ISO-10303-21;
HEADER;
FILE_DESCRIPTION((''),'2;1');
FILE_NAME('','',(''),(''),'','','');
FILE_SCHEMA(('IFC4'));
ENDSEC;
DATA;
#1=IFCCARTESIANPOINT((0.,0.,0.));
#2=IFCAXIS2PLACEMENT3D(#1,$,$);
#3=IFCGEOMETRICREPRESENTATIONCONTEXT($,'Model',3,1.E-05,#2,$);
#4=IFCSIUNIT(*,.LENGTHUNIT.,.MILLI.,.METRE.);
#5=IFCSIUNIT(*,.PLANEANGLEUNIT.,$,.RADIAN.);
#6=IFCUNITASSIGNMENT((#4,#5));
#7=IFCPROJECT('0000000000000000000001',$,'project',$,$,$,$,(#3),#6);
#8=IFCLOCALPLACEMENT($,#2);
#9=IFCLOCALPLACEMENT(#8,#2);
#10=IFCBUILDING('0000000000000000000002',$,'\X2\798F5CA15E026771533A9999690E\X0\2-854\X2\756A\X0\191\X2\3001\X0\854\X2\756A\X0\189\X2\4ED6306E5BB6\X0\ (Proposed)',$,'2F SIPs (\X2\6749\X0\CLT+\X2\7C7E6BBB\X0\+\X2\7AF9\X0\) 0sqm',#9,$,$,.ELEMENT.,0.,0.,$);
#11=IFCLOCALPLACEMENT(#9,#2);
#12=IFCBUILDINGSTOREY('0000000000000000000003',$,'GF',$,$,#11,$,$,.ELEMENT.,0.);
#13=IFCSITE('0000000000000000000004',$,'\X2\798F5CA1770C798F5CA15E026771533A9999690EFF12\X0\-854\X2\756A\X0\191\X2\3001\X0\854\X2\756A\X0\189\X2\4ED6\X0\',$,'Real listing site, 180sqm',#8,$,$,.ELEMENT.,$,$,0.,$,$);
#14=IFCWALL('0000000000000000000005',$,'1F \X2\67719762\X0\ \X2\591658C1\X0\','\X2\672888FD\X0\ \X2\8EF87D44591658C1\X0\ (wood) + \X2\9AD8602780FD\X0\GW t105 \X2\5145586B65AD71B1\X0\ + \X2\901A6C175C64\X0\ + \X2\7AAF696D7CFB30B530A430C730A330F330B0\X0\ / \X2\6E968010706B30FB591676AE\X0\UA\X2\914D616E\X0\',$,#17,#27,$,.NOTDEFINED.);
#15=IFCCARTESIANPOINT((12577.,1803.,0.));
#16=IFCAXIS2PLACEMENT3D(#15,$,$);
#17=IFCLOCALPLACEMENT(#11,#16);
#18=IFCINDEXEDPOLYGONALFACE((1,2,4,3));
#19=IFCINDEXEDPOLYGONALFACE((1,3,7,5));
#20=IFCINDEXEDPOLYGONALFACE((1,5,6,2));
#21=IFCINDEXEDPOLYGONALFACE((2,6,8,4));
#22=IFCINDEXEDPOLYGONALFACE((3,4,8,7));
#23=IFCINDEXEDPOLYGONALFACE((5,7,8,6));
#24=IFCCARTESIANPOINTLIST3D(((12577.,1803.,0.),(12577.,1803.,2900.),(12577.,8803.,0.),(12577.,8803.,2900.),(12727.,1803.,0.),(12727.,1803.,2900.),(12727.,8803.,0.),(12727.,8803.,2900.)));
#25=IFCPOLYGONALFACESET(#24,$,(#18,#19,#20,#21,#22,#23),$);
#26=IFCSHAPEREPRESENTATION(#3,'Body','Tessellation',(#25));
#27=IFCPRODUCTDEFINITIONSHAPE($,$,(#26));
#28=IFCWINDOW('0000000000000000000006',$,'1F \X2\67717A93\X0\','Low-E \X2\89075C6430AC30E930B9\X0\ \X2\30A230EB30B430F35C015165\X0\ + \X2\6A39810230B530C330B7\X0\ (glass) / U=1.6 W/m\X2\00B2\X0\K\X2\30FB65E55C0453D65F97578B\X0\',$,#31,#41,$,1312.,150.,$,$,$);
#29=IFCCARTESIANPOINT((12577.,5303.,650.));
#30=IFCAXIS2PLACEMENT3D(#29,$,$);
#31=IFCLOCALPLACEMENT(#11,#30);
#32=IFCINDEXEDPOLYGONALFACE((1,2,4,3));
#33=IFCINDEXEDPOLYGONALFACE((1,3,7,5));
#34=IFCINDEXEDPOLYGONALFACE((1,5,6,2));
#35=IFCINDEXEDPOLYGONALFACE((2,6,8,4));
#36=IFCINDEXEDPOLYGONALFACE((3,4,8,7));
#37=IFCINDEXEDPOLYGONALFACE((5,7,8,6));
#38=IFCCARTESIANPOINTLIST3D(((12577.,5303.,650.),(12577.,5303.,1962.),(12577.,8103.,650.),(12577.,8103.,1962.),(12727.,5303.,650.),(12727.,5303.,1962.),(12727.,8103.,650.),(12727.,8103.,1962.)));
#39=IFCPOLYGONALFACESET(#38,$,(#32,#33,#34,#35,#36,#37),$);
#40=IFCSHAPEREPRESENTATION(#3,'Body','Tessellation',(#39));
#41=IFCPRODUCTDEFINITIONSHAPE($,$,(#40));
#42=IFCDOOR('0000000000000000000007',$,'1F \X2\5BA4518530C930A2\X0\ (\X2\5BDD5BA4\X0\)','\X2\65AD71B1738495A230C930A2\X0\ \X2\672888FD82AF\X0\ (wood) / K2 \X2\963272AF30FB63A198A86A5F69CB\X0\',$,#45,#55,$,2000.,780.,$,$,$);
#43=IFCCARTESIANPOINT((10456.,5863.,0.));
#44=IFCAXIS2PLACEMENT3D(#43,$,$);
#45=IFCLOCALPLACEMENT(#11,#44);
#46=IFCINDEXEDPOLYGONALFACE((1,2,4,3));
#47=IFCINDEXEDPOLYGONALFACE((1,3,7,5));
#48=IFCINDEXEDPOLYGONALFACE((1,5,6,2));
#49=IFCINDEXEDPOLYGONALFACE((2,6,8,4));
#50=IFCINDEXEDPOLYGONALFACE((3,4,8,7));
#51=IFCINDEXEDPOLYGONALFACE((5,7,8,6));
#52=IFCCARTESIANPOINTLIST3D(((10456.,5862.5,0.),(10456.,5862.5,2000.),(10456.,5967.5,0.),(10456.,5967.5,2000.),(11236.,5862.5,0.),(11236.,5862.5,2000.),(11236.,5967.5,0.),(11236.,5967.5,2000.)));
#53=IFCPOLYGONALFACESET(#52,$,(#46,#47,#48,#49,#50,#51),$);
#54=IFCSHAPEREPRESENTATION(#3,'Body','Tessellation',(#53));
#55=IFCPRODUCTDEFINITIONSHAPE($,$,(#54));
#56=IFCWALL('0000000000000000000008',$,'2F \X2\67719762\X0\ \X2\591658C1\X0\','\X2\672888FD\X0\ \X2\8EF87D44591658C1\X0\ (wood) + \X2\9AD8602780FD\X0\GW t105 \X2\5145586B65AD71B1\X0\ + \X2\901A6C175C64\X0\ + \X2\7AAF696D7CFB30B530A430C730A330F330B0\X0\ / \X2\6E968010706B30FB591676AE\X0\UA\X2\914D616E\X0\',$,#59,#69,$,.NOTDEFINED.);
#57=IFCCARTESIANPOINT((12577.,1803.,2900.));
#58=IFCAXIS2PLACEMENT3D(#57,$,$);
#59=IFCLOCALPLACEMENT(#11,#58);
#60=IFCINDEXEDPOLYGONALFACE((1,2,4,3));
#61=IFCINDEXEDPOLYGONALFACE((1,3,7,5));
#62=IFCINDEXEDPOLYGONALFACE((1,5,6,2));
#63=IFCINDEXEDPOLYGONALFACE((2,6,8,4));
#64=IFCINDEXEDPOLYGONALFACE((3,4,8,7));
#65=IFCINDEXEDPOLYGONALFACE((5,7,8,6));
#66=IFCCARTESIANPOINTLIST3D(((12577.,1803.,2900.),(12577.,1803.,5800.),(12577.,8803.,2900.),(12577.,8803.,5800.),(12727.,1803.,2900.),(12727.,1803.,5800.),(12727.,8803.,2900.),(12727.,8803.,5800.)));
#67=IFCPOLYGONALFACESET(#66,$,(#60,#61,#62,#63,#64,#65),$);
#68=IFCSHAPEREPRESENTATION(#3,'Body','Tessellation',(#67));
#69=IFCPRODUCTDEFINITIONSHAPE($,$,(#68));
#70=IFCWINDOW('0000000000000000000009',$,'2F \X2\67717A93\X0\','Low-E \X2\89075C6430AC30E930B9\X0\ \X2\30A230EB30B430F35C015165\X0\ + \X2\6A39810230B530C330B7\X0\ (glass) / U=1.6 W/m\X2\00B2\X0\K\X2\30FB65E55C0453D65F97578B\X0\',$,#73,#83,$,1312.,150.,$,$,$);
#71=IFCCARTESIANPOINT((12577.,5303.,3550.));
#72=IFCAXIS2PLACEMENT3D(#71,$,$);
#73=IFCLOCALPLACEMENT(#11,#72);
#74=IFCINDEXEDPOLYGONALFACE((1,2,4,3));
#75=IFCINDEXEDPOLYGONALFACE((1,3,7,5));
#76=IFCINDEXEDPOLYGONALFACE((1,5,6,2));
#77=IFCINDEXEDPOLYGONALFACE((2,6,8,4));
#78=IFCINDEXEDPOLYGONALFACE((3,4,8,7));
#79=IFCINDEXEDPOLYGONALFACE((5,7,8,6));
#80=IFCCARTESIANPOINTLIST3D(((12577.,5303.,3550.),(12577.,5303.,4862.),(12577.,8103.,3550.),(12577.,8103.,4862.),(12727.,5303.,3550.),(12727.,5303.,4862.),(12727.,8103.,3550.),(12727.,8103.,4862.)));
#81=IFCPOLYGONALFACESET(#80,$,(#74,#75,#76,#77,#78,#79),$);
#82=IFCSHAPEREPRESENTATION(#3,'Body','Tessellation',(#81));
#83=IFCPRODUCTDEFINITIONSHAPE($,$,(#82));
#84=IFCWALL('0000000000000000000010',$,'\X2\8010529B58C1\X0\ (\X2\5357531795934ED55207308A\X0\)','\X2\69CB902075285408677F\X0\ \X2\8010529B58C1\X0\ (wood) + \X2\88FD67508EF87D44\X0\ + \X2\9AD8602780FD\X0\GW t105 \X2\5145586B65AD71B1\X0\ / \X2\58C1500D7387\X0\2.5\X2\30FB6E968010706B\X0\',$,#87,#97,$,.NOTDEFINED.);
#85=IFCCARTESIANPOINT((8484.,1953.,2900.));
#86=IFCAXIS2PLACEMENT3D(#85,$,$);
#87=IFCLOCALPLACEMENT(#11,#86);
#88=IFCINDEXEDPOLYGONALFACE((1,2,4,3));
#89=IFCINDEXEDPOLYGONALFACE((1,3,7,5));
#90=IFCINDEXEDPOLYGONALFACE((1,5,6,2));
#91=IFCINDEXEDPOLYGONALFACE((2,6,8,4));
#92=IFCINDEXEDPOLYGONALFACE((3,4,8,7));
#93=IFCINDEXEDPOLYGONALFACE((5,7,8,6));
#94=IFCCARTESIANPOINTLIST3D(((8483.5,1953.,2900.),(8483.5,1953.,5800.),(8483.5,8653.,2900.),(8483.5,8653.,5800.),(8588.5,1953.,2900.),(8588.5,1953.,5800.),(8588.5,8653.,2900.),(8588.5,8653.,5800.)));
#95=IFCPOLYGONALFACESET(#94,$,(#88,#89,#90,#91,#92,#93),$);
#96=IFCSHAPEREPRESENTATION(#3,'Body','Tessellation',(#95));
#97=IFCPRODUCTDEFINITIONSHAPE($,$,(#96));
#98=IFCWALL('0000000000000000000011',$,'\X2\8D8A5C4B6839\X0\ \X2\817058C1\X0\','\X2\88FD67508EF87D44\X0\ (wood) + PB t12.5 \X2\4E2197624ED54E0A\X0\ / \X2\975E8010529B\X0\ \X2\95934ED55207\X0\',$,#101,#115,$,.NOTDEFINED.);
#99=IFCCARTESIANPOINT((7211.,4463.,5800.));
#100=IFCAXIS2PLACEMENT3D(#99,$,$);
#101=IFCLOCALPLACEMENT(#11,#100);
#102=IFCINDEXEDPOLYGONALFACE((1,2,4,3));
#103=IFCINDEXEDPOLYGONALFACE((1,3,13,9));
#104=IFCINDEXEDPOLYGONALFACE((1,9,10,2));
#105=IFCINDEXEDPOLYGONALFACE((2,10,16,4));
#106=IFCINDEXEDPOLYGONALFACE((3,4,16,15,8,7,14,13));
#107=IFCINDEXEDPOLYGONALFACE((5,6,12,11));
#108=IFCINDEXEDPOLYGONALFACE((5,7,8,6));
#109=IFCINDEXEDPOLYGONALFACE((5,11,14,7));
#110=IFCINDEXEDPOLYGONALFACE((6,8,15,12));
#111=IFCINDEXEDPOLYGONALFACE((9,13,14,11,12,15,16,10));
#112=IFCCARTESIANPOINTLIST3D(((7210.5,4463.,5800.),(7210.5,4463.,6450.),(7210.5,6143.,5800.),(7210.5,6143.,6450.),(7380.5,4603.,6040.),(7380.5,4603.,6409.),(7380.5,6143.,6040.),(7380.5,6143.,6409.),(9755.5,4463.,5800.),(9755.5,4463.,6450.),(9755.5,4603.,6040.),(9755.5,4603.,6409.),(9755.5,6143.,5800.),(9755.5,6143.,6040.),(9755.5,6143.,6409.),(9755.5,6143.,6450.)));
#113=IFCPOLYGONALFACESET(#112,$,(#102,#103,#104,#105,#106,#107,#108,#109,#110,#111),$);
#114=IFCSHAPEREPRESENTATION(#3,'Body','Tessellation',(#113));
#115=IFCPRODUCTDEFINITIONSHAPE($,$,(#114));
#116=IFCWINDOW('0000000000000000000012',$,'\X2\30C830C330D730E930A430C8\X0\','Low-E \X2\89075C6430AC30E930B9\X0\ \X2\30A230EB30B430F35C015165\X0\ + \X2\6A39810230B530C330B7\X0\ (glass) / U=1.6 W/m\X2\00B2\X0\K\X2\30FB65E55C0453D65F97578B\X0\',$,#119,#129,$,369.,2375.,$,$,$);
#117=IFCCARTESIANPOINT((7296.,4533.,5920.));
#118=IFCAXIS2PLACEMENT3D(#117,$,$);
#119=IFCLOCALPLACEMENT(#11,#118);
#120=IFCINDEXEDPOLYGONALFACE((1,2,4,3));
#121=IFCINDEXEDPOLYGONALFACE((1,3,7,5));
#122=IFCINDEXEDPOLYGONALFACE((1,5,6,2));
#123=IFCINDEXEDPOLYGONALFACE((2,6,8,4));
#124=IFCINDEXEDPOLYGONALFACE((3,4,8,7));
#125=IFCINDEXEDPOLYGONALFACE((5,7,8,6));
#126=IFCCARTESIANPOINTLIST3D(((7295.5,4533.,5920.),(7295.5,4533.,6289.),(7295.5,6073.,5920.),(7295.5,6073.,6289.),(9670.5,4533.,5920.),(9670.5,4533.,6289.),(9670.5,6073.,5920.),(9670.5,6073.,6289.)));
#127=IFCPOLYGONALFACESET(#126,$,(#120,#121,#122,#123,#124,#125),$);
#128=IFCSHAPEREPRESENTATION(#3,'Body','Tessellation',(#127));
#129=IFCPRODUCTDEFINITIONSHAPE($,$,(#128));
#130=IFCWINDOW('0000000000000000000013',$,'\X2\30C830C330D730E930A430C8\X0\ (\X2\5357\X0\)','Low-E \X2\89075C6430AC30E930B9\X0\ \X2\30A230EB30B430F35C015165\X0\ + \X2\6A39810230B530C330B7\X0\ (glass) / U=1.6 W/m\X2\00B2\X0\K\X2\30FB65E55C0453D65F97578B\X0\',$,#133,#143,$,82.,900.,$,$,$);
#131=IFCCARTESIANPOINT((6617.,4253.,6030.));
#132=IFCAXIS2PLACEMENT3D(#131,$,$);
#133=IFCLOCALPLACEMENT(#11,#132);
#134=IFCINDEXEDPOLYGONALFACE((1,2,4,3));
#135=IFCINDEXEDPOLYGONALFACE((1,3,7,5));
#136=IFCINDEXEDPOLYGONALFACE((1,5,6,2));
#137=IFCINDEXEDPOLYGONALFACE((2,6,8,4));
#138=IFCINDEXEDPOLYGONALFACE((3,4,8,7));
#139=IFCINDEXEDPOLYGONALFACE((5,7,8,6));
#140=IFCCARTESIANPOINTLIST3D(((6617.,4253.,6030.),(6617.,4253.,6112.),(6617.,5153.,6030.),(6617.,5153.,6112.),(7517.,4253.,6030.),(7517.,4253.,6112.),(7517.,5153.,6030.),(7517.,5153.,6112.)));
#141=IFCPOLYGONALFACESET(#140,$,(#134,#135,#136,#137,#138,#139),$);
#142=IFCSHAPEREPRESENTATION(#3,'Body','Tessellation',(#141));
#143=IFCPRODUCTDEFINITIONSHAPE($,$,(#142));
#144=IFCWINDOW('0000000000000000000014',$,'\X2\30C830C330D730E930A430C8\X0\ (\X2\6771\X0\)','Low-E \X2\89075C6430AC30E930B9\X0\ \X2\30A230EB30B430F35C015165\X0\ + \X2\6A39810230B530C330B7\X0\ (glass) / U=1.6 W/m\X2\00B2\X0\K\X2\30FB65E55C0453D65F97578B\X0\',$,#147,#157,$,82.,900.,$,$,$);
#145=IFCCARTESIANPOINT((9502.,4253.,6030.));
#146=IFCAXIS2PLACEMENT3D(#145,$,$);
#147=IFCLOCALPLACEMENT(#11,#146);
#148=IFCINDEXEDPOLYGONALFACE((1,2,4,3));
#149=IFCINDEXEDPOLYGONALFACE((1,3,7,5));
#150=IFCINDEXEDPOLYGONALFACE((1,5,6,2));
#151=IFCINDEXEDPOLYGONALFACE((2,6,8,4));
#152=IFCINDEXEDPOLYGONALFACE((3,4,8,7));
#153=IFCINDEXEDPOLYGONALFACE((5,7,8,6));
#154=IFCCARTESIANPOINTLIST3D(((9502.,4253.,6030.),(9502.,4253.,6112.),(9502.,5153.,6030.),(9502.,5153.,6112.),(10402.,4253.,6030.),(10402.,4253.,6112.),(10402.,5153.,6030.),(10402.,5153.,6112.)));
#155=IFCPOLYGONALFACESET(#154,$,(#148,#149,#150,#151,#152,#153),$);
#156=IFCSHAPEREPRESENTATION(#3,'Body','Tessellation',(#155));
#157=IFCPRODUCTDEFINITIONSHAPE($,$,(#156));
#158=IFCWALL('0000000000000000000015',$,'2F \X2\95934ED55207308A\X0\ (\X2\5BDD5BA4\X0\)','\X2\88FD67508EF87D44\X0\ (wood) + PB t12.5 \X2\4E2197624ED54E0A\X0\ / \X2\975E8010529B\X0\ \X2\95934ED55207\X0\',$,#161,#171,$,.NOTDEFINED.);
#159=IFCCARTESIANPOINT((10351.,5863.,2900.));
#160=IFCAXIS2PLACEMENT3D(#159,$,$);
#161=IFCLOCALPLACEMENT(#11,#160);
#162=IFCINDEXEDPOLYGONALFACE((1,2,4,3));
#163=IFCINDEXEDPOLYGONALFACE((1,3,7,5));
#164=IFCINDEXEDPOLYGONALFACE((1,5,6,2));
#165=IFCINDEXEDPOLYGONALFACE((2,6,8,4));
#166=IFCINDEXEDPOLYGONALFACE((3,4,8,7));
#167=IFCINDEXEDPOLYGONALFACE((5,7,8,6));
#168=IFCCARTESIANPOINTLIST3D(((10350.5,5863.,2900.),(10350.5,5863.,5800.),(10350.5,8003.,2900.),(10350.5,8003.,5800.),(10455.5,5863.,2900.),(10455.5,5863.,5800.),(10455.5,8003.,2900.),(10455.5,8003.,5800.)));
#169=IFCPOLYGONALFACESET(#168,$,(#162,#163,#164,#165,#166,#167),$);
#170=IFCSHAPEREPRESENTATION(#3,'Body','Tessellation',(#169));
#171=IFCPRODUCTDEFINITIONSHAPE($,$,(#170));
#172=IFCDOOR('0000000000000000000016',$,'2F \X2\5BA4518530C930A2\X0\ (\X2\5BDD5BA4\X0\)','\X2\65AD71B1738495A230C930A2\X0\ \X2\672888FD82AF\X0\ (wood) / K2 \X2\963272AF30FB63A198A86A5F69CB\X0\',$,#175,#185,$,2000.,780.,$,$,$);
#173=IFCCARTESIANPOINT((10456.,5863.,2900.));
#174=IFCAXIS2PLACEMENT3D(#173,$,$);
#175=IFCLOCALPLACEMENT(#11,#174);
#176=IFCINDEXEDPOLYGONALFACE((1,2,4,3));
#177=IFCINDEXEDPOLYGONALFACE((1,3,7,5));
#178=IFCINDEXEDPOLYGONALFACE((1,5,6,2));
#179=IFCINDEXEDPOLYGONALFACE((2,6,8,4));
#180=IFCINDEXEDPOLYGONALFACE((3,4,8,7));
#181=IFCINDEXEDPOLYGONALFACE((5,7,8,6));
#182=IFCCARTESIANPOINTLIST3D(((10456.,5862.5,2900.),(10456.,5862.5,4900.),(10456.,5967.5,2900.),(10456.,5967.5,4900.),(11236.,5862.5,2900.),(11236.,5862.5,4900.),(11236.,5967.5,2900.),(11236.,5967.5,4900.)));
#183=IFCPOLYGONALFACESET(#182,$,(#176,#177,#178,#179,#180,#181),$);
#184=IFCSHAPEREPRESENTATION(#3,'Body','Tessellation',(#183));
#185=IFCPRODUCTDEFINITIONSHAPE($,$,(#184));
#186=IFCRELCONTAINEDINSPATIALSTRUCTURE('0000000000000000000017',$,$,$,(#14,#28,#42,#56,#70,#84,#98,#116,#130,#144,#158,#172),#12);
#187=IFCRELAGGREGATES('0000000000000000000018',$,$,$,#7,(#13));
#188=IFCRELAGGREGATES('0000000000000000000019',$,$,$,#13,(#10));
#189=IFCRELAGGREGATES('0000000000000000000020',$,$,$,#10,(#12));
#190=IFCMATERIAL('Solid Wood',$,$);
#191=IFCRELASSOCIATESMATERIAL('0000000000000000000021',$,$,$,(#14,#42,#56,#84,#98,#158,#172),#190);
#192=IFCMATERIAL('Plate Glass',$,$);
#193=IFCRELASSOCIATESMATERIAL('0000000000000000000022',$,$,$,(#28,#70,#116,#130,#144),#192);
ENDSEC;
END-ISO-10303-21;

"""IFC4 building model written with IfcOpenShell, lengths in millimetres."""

from ifc_helpers import new_model, si_unit, frame, frame_2d, origin, place, context, project, spatial, rectangle, extrude, material, element, fill, save


model = new_model("IFC4")

# Units and contexts
model_context = context("Model", 3, precision=1e-05, world=origin())
ifc_project = project(units=[si_unit("LENGTHUNIT", "METRE", prefix="MILLI"), si_unit("PLANEANGLEUNIT", "RADIAN")], contexts=[model_context])

# Site, building, storey
site_placement = place(None, origin())
site = spatial("IfcSite", under=ifc_project, at=site_placement, Name="福岡県福岡市東区香椎２-854番191、854番189他", ObjectType="Real listing site, 180sqm", CompositionType="ELEMENT", RefElevation=0.0)
building_placement = place(site_placement, origin())
building = spatial("IfcBuilding", under=site, at=building_placement, Name="福岡市東区香椎2-854番191、854番189他の家 (Proposed)", ObjectType="2F SIPs (杉CLT+籾殻+竹) 0sqm", CompositionType="ELEMENT", ElevationOfRefHeight=0.0, ElevationOfTerrain=0.0)
storey_placement = place(building_placement, origin())
storey = spatial("IfcBuildingStorey", under=building, at=storey_placement, Name="GF", CompositionType="ELEMENT", Elevation=0.0)

# Wall, opening, window
ifc_material_1 = material(Name="Solid Wood")
wall_1_placement = place(storey_placement, frame((12577.0, 1803.0, 0.0)))
wall_1 = element("IfcWall", 1, at=wall_1_placement, inside=storey, material=ifc_material_1, Name="1F 東面 外壁", Description="木製 軸組外壁 (wood) + 高性能GW t105 充填断熱 + 通気層 + 窯業系サイディング / 準耐火・外皮UA配慮", PredefinedType="NOTDEFINED", context=model_context, shape_type="SweptSolid", body=[
    extrude(rectangle(XDim=150.0, YDim=7000.0, at=frame_2d((75.0, 3500.0))), frame((12577.0, 1803.0, 0.0)), (0.0, 0.0, 1.0), 2900.0),
])
opening_1_placement = place(storey_placement, frame((12577.0, 5303.0, 650.0)))
opening_1 = element("IfcOpeningElement", 2, at=opening_1_placement, cuts=wall_1, PredefinedType="NOTDEFINED", context=model_context, shape_type="SweptSolid", body=[
    extrude(rectangle(XDim=150.0, YDim=2800.0, at=frame_2d((75.0, 1400.0))), frame((12577.0, 5303.0, 650.0)), (0.0, 0.0, 1.0), 1312.0),
])
ifc_material_2 = material(Name="Plate Glass")
window_1_placement = place(storey_placement, frame((12577.0, 5303.0, 650.0)))
window_1 = element("IfcWindow", 3, at=window_1_placement, inside=storey, material=ifc_material_2, Name="1F 東窓", Description="Low-E 複層ガラス アルゴン封入 + 樹脂サッシ (glass) / U=1.6 W/m²K・日射取得型", OverallHeight=1312.0, OverallWidth=150.0, context=model_context, shape_type="SweptSolid", body=[
    extrude(rectangle(XDim=150.0, YDim=2800.0, at=frame_2d((75.0, 1400.0))), frame((12577.0, 5303.0, 650.0)), (0.0, 0.0, 1.0), 1312.0),
])
fill(opening_1, window_1)

# Door
door_1_placement = place(storey_placement, frame((10456.0, 5863.0, 0.0)))
element("IfcDoor", 4, at=door_1_placement, inside=storey, material=ifc_material_1, Name="1F 室内ドア (寝室)", Description="断熱玄関ドア 木製芯 (wood) / K2 防犯・採風機構", OverallHeight=2000.0, OverallWidth=780.0, context=model_context, shape_type="SweptSolid", body=[
    extrude(rectangle(XDim=780.0, YDim=105.0, at=frame_2d((390.0, 52.0))), frame((10456.0, 5863.0, 0.0)), (0.0, 0.0, 1.0), 2000.0),
])

# Wall, opening, window
wall_2_placement = place(storey_placement, frame((12577.0, 1803.0, 2900.0)))
wall_2 = element("IfcWall", 5, at=wall_2_placement, inside=storey, material=ifc_material_1, Name="2F 東面 外壁", Description="木製 軸組外壁 (wood) + 高性能GW t105 充填断熱 + 通気層 + 窯業系サイディング / 準耐火・外皮UA配慮", PredefinedType="NOTDEFINED", context=model_context, shape_type="SweptSolid", body=[
    extrude(rectangle(XDim=150.0, YDim=7000.0, at=frame_2d((75.0, 3500.0))), frame((12577.0, 1803.0, 2900.0)), (0.0, 0.0, 1.0), 2900.0),
])
opening_2_placement = place(storey_placement, frame((12577.0, 5303.0, 3550.0)))
opening_2 = element("IfcOpeningElement", 6, at=opening_2_placement, cuts=wall_2, PredefinedType="NOTDEFINED", context=model_context, shape_type="SweptSolid", body=[
    extrude(rectangle(XDim=150.0, YDim=2800.0, at=frame_2d((75.0, 1400.0))), frame((12577.0, 5303.0, 3550.0)), (0.0, 0.0, 1.0), 1312.0),
])
window_2_placement = place(storey_placement, frame((12577.0, 5303.0, 3550.0)))
window_2 = element("IfcWindow", 7, at=window_2_placement, inside=storey, material=ifc_material_2, Name="2F 東窓", Description="Low-E 複層ガラス アルゴン封入 + 樹脂サッシ (glass) / U=1.6 W/m²K・日射取得型", OverallHeight=1312.0, OverallWidth=150.0, context=model_context, shape_type="SweptSolid", body=[
    extrude(rectangle(XDim=150.0, YDim=2800.0, at=frame_2d((75.0, 1400.0))), frame((12577.0, 5303.0, 3550.0)), (0.0, 0.0, 1.0), 1312.0),
])
fill(opening_2, window_2)

# Wall
wall_3_placement = place(storey_placement, frame((8484.0, 1953.0, 2900.0)))
element("IfcWall", 8, at=wall_3_placement, inside=storey, material=ifc_material_1, Name="耐力壁 (南北間仕切り)", Description="構造用合板 耐力壁 (wood) + 製材軸組 + 高性能GW t105 充填断熱 / 壁倍率2.5・準耐火", PredefinedType="NOTDEFINED", context=model_context, shape_type="SweptSolid", body=[
    extrude(rectangle(XDim=105.0, YDim=6700.0, at=frame_2d((52.0, 3350.0))), frame((8484.0, 1953.0, 2900.0)), (0.0, 0.0, 1.0), 2900.0),
])

# Wall, openings, windows
wall_4_placement = place(storey_placement, frame((7211.0, 4463.0, 5800.0)))
wall_4 = element("IfcWall", 9, at=wall_4_placement, inside=storey, material=ifc_material_1, Name="越屋根 腰壁", Description="製材軸組 (wood) + PB t12.5 両面仕上 / 非耐力 間仕切", PredefinedType="NOTDEFINED", context=model_context, shape_type="SweptSolid", body=[
    extrude(rectangle(XDim=2545.0, YDim=1680.0, at=frame_2d((1272.0, 840.0))), frame((7211.0, 4463.0, 5800.0)), (0.0, 0.0, 1.0), 650.0),
])
opening_3_placement = place(storey_placement, frame((7296.0, 4533.0, 5920.0)))
opening_3 = element("IfcOpeningElement", 10, at=opening_3_placement, cuts=wall_4, PredefinedType="NOTDEFINED", context=model_context, shape_type="SweptSolid", body=[
    extrude(rectangle(XDim=2375.0, YDim=1540.0, at=frame_2d((1187.0, 770.0))), frame((7296.0, 4533.0, 5920.0)), (0.0, 0.0, 1.0), 369.0),
])
opening_4_placement = place(storey_placement, frame((6617.0, 4253.0, 6030.0)))
opening_4 = element("IfcOpeningElement", 11, at=opening_4_placement, cuts=wall_4, PredefinedType="NOTDEFINED", context=model_context, shape_type="SweptSolid", body=[
    extrude(rectangle(XDim=900.0, YDim=900.0, at=frame_2d((450.0, 450.0))), frame((6617.0, 4253.0, 6030.0)), (0.0, 0.0, 1.0), 82.0),
])
opening_5_placement = place(storey_placement, frame((9502.0, 4253.0, 6030.0)))
opening_5 = element("IfcOpeningElement", 12, at=opening_5_placement, cuts=wall_4, PredefinedType="NOTDEFINED", context=model_context, shape_type="SweptSolid", body=[
    extrude(rectangle(XDim=900.0, YDim=900.0, at=frame_2d((450.0, 450.0))), frame((9502.0, 4253.0, 6030.0)), (0.0, 0.0, 1.0), 82.0),
])
window_3_placement = place(storey_placement, frame((7296.0, 4533.0, 5920.0)))
window_3 = element("IfcWindow", 13, at=window_3_placement, inside=storey, material=ifc_material_2, Name="トップライト", Description="Low-E 複層ガラス アルゴン封入 + 樹脂サッシ (glass) / U=1.6 W/m²K・日射取得型", OverallHeight=369.0, OverallWidth=2375.0, context=model_context, shape_type="SweptSolid", body=[
    extrude(rectangle(XDim=2375.0, YDim=1540.0, at=frame_2d((1187.0, 770.0))), frame((7296.0, 4533.0, 5920.0)), (0.0, 0.0, 1.0), 369.0),
])
fill(opening_3, window_3)
window_4_placement = place(storey_placement, frame((6617.0, 4253.0, 6030.0)))
window_4 = element("IfcWindow", 14, at=window_4_placement, inside=storey, material=ifc_material_2, Name="トップライト (南)", Description="Low-E 複層ガラス アルゴン封入 + 樹脂サッシ (glass) / U=1.6 W/m²K・日射取得型", OverallHeight=82.0, OverallWidth=900.0, context=model_context, shape_type="SweptSolid", body=[
    extrude(rectangle(XDim=900.0, YDim=900.0, at=frame_2d((450.0, 450.0))), frame((6617.0, 4253.0, 6030.0)), (0.0, 0.0, 1.0), 82.0),
])
fill(opening_4, window_4)
window_5_placement = place(storey_placement, frame((9502.0, 4253.0, 6030.0)))
window_5 = element("IfcWindow", 15, at=window_5_placement, inside=storey, material=ifc_material_2, Name="トップライト (東)", Description="Low-E 複層ガラス アルゴン封入 + 樹脂サッシ (glass) / U=1.6 W/m²K・日射取得型", OverallHeight=82.0, OverallWidth=900.0, context=model_context, shape_type="SweptSolid", body=[
    extrude(rectangle(XDim=900.0, YDim=900.0, at=frame_2d((450.0, 450.0))), frame((9502.0, 4253.0, 6030.0)), (0.0, 0.0, 1.0), 82.0),
])
fill(opening_5, window_5)

# Wall
wall_5_placement = place(storey_placement, frame((10351.0, 5863.0, 2900.0)))
element("IfcWall", 16, at=wall_5_placement, inside=storey, material=ifc_material_1, Name="2F 間仕切り (寝室)", Description="製材軸組 (wood) + PB t12.5 両面仕上 / 非耐力 間仕切", PredefinedType="NOTDEFINED", context=model_context, shape_type="SweptSolid", body=[
    extrude(rectangle(XDim=105.0, YDim=2140.0, at=frame_2d((52.0, 1070.0))), frame((10351.0, 5863.0, 2900.0)), (0.0, 0.0, 1.0), 2900.0),
])

# Door
door_2_placement = place(storey_placement, frame((10456.0, 5863.0, 2900.0)))
element("IfcDoor", 17, at=door_2_placement, inside=storey, material=ifc_material_1, Name="2F 室内ドア (寝室)", Description="断熱玄関ドア 木製芯 (wood) / K2 防犯・採風機構", OverallHeight=2000.0, OverallWidth=780.0, context=model_context, shape_type="SweptSolid", body=[
    extrude(rectangle(XDim=780.0, YDim=105.0, at=frame_2d((390.0, 52.0))), frame((10456.0, 5863.0, 2900.0)), (0.0, 0.0, 1.0), 2000.0),
])

save(model, "model.ifc")
